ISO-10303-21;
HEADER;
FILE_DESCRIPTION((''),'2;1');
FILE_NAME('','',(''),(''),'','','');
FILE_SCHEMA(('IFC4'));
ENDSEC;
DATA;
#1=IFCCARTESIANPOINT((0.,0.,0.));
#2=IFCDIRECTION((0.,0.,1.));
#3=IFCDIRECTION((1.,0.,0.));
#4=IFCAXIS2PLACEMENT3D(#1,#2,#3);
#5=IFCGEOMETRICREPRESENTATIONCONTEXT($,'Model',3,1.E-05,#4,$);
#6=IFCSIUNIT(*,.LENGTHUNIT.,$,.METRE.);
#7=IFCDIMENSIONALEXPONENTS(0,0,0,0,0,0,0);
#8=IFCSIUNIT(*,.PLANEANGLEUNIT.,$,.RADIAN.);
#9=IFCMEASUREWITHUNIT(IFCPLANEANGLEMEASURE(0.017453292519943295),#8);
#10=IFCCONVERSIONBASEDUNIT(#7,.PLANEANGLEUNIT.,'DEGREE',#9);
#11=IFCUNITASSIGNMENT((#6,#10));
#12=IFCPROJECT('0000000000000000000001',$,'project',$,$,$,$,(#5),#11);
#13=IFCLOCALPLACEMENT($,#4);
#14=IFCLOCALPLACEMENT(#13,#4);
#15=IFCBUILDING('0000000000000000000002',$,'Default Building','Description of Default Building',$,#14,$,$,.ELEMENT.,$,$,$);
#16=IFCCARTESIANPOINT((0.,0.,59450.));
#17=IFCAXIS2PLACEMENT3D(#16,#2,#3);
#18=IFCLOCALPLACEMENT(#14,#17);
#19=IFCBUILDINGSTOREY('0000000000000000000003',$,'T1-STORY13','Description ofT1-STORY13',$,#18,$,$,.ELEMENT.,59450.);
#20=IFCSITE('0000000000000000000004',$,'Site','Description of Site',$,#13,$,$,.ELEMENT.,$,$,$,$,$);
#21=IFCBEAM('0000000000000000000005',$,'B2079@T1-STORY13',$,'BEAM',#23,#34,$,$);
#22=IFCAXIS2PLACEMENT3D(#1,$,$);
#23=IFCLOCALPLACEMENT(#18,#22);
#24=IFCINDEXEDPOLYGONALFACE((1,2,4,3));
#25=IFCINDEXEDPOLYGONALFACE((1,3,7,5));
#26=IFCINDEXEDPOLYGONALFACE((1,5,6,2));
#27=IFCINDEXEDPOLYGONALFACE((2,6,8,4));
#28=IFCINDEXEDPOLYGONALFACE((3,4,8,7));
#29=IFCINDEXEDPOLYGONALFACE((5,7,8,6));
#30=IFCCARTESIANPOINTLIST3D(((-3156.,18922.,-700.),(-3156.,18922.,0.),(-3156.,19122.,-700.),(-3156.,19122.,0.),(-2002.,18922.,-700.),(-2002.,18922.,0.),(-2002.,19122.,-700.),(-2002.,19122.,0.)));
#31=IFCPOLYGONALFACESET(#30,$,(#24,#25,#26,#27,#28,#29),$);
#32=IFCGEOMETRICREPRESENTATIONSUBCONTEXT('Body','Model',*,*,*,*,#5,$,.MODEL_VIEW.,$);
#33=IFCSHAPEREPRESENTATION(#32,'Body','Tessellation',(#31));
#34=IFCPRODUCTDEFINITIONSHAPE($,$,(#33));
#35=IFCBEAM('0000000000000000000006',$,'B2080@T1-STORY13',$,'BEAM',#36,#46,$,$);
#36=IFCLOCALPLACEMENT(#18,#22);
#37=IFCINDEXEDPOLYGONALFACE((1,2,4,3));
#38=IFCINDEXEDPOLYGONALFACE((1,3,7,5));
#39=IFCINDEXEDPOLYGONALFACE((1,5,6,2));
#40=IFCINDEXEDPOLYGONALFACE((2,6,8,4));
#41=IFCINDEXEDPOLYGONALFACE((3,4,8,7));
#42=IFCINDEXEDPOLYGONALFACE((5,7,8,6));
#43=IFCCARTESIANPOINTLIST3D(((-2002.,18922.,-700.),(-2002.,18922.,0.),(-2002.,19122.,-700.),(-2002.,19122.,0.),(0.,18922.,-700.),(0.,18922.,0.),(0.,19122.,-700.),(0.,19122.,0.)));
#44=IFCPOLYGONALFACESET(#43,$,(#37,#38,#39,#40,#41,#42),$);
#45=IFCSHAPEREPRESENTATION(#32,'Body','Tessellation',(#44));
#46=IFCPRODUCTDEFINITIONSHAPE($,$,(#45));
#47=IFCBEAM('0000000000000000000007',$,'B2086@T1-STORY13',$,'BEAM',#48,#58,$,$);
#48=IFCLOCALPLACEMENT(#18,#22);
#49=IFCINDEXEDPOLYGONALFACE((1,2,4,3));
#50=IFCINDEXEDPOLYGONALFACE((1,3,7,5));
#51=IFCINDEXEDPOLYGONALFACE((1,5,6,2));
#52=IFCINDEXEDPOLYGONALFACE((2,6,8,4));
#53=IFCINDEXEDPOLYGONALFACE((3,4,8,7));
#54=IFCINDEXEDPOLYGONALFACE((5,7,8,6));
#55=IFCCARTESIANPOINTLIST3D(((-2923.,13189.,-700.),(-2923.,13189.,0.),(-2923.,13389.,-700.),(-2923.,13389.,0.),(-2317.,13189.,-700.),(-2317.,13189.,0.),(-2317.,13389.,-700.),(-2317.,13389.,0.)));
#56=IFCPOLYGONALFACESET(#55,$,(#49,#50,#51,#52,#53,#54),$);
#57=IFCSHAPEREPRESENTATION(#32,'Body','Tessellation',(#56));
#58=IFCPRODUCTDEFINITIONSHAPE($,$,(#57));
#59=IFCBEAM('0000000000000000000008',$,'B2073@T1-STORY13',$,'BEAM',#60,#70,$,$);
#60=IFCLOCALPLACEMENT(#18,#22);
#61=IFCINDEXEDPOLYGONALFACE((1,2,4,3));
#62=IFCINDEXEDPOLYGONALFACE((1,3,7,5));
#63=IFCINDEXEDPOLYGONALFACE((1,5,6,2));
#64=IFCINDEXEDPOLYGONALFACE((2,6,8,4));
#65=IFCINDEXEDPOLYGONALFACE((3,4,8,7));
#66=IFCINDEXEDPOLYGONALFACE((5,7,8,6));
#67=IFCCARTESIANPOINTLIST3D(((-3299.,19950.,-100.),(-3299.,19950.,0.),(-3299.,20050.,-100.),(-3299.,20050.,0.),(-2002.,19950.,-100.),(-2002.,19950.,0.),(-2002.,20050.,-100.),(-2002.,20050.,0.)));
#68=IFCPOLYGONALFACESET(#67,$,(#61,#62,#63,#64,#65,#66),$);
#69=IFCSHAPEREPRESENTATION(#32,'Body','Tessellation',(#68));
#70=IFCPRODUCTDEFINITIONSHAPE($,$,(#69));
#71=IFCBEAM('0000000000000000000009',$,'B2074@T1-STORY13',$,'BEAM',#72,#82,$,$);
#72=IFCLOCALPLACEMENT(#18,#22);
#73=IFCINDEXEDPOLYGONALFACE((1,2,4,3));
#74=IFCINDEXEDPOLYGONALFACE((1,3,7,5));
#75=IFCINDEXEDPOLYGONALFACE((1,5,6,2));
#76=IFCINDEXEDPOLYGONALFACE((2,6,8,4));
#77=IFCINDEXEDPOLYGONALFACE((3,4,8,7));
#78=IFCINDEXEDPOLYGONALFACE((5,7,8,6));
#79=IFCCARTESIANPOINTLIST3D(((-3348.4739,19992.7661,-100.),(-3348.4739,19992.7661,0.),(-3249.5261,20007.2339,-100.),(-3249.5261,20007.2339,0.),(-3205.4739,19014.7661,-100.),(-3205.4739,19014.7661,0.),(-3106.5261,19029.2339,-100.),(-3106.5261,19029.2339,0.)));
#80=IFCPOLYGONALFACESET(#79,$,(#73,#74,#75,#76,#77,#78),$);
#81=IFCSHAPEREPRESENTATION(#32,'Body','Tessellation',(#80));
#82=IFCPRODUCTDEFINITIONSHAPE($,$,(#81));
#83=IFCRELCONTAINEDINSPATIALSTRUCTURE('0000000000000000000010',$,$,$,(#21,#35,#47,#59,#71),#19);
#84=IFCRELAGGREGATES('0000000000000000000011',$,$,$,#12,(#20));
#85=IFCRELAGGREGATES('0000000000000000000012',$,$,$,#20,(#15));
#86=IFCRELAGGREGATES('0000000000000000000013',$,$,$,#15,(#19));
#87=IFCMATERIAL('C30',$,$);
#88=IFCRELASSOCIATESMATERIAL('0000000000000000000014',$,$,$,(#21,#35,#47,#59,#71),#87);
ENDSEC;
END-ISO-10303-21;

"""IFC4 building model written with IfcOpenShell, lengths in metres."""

from ifc_helpers import new_model, entity, si_unit, converted_unit, frame, origin_with_axes, place, context, subcontext, project, spatial, rectangle, extrude, material, element, save


model = new_model("IFC4")

# Units and contexts
model_context = context("Model", 3, precision=1e-05, world=origin_with_axes())
body_context = subcontext(model_context, "Body", "Model", "MODEL_VIEW")
ifc_project = project(units=[si_unit("LENGTHUNIT", "METRE"), converted_unit("PLANEANGLEUNIT", "DEGREE", entity("IfcPlaneAngleMeasure", 0.017453292519943295), si_unit("PLANEANGLEUNIT", "RADIAN"), dimensions=[0, 0, 0, 0, 0, 0, 0])], contexts=[model_context])

# Site, building, storey
site_placement = place(None, origin_with_axes())
site = spatial("IfcSite", under=ifc_project, at=site_placement, Name="Site", Description="Description of Site", CompositionType="ELEMENT")
building_placement = place(site_placement, origin_with_axes())
building = spatial("IfcBuilding", under=site, at=building_placement, Name="Default Building", Description="Description of Default Building", CompositionType="ELEMENT")
storey_placement = place(building_placement, frame((0.0, 0.0, 59450.0), z_axis=(0.0, 0.0, 1.0), x_axis=(1.0, 0.0, 0.0)))
storey = spatial("IfcBuildingStorey", under=building, at=storey_placement, Name="T1-STORY13", Description="Description ofT1-STORY13", CompositionType="ELEMENT", Elevation=59450.0)

# Beams
ifc_material_1 = material(Name="C30")
beam_1_placement = place(storey_placement, frame((-3156.0, 19022.0, -350.0), z_axis=(1.0, 0.0, 0.0), x_axis=(0.0, 1.0, 0.0)))
element("IfcBeam", 1, at=beam_1_placement, inside=storey, material=ifc_material_1, Name="B2079@T1-STORY13", ObjectType="BEAM", context=body_context, shape_type="SweptSolid", body=[
    extrude(rectangle(XDim=200.0, YDim=700.0), origin_with_axes(), (0.0, 0.0, 1.0), 1154.0),
])
beam_2_placement = place(storey_placement, frame((-2002.0, 19022.0, -350.0), z_axis=(1.0, 0.0, 0.0), x_axis=(0.0, 1.0, 0.0)))
element("IfcBeam", 2, at=beam_2_placement, inside=storey, material=ifc_material_1, Name="B2080@T1-STORY13", ObjectType="BEAM", context=body_context, shape_type="SweptSolid", body=[
    extrude(rectangle(XDim=200.0, YDim=700.0), origin_with_axes(), (0.0, 0.0, 1.0), 2002.0),
])
beam_3_placement = place(storey_placement, frame((-2923.0, 13289.0, -350.0), z_axis=(1.0, 0.0, 0.0), x_axis=(0.0, 1.0, 0.0)))
element("IfcBeam", 3, at=beam_3_placement, inside=storey, material=ifc_material_1, Name="B2086@T1-STORY13", ObjectType="BEAM", context=body_context, shape_type="SweptSolid", body=[
    extrude(rectangle(XDim=200.0, YDim=700.0), origin_with_axes(), (0.0, 0.0, 1.0), 606.0),
])
beam_4_placement = place(storey_placement, frame((-3299.0, 20000.0, -50.0), z_axis=(1.0, 0.0, 0.0), x_axis=(0.0, 1.0, 0.0)))
element("IfcBeam", 4, at=beam_4_placement, inside=storey, material=ifc_material_1, Name="B2073@T1-STORY13", ObjectType="BEAM", context=body_context, shape_type="SweptSolid", body=[
    extrude(rectangle(XDim=100.0, YDim=100.0), origin_with_axes(), (0.0, 0.0, 1.0), 1297.0),
])
beam_5_placement = place(storey_placement, frame((-3299.0, 20000.0, -50.0), z_axis=(0.144678, -0.989479, 0.0), x_axis=(0.989479, 0.144678, 0.0)))
element("IfcBeam", 5, at=beam_5_placement, inside=storey, material=ifc_material_1, Name="B2074@T1-STORY13", ObjectType="BEAM", context=body_context, shape_type="SweptSolid", body=[
    extrude(rectangle(XDim=100.0, YDim=100.0), origin_with_axes(), (0.0, 0.0, 1.0), 988.3992),
])

save(model, "model.ifc")
